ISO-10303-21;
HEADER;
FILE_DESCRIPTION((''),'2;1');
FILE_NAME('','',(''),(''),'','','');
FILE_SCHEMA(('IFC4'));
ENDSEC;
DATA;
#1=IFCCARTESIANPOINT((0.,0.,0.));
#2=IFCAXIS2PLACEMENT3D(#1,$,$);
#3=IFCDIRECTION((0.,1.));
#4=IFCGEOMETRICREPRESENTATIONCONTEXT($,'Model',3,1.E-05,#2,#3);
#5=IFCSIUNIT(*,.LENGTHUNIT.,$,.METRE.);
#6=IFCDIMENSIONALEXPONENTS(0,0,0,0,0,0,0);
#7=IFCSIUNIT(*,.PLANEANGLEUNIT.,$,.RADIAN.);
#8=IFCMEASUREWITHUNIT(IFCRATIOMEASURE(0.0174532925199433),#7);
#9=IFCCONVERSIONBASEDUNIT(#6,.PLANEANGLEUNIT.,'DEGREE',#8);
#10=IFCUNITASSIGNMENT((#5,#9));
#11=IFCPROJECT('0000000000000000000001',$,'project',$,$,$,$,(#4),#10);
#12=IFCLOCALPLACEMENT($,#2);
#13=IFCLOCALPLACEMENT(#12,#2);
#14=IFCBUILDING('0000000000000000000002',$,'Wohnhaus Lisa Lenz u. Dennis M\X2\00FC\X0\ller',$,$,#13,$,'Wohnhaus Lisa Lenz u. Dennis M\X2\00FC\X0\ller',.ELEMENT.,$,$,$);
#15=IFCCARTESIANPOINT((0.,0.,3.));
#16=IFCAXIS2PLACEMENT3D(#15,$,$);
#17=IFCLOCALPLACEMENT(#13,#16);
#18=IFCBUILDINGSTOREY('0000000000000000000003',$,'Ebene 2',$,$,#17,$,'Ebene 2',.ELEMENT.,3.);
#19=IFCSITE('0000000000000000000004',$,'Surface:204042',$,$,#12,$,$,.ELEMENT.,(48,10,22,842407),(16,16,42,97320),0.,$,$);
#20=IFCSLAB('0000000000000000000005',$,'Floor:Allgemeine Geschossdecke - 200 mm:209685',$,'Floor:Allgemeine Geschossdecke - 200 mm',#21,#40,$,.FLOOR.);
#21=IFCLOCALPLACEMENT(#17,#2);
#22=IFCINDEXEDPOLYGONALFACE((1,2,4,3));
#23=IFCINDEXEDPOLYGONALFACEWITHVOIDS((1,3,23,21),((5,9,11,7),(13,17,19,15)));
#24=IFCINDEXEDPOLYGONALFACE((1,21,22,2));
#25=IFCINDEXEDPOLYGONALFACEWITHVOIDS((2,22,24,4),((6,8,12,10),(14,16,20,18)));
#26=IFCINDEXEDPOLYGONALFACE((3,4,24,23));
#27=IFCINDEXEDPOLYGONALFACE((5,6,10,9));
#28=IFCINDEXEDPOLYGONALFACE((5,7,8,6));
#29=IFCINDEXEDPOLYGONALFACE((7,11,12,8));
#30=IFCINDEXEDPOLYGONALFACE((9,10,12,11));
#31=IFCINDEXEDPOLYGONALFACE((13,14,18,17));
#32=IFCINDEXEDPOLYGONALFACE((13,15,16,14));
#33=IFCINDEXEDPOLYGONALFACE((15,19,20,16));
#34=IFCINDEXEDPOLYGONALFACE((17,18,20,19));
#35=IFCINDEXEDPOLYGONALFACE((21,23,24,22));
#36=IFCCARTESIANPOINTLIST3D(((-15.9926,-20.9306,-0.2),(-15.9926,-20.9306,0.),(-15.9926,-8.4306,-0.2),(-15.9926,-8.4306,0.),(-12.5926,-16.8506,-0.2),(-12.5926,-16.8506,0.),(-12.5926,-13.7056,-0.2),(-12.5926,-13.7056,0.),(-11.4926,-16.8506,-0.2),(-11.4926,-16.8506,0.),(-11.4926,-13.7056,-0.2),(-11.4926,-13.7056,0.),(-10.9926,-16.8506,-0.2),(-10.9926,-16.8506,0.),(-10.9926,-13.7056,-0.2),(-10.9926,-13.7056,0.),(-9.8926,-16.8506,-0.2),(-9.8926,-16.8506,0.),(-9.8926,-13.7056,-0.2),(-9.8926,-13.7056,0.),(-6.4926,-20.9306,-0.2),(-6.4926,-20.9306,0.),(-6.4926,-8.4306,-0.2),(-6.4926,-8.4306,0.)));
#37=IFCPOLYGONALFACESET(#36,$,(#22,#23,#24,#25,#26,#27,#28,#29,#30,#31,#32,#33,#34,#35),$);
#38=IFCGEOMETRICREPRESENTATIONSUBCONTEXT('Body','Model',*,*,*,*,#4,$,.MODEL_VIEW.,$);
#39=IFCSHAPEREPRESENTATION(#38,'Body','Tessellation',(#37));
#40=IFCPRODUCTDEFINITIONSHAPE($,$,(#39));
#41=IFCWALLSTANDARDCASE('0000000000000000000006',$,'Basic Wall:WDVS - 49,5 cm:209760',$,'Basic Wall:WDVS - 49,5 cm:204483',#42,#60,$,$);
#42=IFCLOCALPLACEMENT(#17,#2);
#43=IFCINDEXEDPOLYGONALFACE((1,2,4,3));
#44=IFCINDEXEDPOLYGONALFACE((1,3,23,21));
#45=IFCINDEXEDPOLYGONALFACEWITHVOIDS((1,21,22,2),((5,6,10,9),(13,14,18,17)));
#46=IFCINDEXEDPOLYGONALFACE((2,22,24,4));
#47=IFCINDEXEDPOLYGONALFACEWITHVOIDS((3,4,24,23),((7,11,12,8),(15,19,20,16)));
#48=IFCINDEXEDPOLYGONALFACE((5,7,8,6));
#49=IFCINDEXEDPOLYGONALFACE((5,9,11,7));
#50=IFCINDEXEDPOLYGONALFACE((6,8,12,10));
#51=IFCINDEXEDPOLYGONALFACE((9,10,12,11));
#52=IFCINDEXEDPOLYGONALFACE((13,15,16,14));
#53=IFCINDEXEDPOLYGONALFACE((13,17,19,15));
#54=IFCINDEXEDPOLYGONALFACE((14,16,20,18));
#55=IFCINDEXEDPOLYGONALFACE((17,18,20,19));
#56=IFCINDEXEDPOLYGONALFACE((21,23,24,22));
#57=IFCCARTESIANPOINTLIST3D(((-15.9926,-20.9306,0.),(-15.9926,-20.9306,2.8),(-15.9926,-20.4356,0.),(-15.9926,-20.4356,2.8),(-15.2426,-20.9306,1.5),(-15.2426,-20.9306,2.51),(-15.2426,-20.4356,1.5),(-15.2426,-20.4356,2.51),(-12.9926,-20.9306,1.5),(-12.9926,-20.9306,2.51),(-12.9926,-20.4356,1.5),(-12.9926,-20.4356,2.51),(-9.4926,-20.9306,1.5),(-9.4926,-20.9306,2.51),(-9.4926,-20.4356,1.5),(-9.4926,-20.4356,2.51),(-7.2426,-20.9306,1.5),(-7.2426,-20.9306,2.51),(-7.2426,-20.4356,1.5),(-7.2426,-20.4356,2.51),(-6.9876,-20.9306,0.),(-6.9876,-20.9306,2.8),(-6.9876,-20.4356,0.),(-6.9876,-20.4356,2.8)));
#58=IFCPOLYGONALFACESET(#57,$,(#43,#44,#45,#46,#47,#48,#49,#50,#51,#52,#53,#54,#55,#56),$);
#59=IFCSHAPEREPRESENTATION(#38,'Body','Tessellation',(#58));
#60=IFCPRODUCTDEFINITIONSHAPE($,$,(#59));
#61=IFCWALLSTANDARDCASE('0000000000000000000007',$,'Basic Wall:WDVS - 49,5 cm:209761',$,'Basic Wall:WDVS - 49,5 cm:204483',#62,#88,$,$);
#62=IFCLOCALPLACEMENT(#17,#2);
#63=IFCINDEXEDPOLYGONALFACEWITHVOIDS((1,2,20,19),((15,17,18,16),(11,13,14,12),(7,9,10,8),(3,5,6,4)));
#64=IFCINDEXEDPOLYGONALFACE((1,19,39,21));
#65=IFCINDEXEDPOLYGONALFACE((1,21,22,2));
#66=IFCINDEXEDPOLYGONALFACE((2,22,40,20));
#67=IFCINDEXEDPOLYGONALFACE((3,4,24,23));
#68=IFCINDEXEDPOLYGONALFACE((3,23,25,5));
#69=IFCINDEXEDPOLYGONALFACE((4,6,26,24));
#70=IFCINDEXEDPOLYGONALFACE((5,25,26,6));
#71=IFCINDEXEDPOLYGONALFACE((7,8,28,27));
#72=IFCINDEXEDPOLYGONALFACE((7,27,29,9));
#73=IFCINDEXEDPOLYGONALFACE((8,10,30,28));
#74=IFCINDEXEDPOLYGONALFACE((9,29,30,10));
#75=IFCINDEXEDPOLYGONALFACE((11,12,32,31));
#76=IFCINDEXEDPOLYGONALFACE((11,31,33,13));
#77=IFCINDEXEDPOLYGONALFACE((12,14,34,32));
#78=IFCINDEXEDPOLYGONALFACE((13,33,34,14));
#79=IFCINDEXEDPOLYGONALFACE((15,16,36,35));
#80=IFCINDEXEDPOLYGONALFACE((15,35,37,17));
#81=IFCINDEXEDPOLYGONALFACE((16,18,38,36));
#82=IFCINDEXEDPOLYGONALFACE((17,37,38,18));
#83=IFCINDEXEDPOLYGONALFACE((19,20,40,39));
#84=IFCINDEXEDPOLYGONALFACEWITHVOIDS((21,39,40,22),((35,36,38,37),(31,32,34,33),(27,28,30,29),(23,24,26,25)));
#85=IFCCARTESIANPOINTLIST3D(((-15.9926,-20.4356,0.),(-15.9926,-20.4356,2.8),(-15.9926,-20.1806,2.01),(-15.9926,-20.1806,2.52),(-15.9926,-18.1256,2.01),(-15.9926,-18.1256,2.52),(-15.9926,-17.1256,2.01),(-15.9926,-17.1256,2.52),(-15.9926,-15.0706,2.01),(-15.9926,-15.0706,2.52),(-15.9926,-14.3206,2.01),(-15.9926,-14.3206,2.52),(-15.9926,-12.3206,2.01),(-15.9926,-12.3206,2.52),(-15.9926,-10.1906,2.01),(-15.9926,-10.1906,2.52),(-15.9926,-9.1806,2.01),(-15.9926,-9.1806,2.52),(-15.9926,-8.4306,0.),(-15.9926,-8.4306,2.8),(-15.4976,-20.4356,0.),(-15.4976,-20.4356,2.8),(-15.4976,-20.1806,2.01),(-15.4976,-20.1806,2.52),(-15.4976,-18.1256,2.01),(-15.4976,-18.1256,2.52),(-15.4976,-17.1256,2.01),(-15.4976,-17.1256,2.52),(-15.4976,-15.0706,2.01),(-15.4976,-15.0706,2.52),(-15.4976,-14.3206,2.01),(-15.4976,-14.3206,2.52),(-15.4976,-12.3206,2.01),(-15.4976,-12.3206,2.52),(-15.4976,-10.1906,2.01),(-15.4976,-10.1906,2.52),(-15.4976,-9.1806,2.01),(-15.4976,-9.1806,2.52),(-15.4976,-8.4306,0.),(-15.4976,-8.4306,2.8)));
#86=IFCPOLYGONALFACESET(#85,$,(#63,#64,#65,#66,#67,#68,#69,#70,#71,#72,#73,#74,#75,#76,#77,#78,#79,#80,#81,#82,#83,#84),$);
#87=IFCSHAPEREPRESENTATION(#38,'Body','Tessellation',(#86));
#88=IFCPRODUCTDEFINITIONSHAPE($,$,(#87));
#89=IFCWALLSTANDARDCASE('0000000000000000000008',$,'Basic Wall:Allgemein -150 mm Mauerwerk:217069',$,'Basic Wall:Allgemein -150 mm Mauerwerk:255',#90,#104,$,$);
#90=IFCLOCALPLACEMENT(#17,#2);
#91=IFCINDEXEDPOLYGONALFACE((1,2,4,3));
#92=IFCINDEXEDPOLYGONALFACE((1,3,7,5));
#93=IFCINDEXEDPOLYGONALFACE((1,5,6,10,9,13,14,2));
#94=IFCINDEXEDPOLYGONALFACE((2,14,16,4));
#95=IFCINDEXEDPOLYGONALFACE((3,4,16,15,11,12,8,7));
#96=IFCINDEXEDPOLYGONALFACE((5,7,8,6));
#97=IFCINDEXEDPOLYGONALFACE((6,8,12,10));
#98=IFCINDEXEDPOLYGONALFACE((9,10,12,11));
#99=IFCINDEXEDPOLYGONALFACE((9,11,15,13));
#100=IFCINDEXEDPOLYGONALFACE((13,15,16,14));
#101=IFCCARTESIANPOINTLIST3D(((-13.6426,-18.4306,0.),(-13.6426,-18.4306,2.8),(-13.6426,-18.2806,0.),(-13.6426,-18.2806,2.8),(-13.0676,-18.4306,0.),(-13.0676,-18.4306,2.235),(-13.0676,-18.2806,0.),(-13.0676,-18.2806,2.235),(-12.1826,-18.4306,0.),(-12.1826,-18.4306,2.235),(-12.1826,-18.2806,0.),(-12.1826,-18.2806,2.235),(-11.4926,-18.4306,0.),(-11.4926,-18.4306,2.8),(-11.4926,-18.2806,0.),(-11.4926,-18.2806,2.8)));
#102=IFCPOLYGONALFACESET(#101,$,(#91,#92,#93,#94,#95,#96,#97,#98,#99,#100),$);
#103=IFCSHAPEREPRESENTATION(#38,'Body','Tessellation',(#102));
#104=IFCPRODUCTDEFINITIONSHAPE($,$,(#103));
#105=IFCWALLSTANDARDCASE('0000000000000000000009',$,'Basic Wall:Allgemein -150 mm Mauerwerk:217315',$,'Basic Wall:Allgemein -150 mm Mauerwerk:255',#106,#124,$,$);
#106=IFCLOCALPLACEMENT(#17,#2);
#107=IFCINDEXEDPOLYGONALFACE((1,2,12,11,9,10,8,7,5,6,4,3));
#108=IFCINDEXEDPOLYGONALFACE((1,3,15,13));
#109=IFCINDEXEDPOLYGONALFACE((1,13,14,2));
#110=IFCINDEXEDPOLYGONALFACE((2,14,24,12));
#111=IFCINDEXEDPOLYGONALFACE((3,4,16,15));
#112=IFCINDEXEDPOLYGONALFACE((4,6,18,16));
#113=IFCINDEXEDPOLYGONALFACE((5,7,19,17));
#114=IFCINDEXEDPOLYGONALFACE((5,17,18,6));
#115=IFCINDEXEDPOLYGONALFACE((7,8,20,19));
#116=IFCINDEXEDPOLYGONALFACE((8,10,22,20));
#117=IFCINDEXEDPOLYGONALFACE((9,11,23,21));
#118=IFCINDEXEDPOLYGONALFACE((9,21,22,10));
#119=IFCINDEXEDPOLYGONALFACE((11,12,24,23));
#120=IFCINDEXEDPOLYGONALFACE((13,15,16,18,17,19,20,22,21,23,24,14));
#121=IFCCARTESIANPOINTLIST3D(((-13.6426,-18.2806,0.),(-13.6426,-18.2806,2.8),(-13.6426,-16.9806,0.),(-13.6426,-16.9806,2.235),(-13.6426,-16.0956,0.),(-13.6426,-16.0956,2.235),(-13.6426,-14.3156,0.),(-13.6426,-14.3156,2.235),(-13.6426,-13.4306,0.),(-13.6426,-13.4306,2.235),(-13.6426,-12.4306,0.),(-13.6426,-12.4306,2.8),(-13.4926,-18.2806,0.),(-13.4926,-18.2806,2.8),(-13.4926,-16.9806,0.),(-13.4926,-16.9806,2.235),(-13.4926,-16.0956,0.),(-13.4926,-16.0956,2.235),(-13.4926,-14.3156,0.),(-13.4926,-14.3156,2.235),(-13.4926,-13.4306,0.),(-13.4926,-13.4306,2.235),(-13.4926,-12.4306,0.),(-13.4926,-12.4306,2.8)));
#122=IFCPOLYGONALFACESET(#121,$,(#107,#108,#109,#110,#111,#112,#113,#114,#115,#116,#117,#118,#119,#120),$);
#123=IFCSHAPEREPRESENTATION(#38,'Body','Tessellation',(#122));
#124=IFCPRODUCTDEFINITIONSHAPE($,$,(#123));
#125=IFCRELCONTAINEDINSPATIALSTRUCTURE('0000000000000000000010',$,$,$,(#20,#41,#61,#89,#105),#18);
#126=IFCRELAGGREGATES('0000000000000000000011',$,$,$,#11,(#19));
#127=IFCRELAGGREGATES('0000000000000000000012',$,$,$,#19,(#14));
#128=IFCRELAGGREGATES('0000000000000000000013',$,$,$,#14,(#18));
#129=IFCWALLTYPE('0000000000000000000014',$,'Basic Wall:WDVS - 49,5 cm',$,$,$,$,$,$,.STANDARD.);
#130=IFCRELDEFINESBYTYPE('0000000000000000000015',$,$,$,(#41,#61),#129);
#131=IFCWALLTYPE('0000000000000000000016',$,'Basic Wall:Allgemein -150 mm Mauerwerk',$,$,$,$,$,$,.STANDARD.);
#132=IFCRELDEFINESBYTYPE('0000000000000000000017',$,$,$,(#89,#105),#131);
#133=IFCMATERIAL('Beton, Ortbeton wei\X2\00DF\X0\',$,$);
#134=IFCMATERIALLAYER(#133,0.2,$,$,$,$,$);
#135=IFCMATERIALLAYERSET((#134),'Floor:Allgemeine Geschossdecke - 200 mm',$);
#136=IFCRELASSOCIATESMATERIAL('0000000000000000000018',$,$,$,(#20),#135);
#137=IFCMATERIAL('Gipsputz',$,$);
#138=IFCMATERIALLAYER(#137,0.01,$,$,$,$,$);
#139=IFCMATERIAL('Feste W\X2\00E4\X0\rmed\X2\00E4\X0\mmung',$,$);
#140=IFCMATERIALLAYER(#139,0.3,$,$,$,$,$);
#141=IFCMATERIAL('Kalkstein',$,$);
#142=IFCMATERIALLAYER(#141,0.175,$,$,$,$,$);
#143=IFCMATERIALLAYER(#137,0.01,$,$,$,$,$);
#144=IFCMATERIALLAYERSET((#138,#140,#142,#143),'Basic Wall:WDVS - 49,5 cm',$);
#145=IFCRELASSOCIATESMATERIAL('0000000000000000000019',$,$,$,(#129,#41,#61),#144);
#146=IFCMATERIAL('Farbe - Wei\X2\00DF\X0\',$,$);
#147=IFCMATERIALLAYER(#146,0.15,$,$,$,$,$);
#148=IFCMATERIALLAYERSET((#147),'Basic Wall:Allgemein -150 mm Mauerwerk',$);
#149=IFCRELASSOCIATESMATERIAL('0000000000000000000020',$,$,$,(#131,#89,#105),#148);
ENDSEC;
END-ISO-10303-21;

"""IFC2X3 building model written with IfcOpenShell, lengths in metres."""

from ifc_helpers import new_model, entity, si_unit, converted_unit, direction, frame, frame_2d, origin, origin_2d_with_axis, place, context, subcontext, project, spatial, polyline, rectangle, extrude, clip, bounded_halfspace, material, layer, layer_set, layer_usage, type_object, element, save


model = new_model("IFC2X3")

# Units and contexts
model_context = context("Model", 3, precision=1e-05, world=origin(), true_north=direction((0.0, 1.0)))
body_context = subcontext(model_context, "Body", "Model", "MODEL_VIEW")
ifc_project = project(units=[si_unit("LENGTHUNIT", "METRE"), converted_unit("PLANEANGLEUNIT", "DEGREE", entity("IfcRatioMeasure", 0.0174532925199433), si_unit("PLANEANGLEUNIT", "RADIAN"), dimensions=[0, 0, 0, 0, 0, 0, 0])], contexts=[model_context])

# Site, building, storey
site_placement = place(None, origin())
site = spatial("IfcSite", under=ifc_project, at=site_placement, Name="Surface:204042", CompositionType="ELEMENT", RefLatitude=(48, 10, 22, 842407), RefLongitude=(16, 16, 42, 97320), RefElevation=0.0)
building_placement = place(site_placement, origin())
building = spatial("IfcBuilding", under=site, at=building_placement, Name="Wohnhaus Lisa Lenz u. Dennis Müller", LongName="Wohnhaus Lisa Lenz u. Dennis Müller", CompositionType="ELEMENT")
storey_placement = place(building_placement, frame((0.0, 0.0, 3.0)))
storey = spatial("IfcBuildingStorey", under=building, at=storey_placement, Name="Ebene 2", LongName="Ebene 2", CompositionType="ELEMENT", Elevation=3.0)

# Slab, openings
ifc_material_1 = material(Name="Beton, Ortbeton weiß")
ifc_layer_1 = layer(ifc_material_1, 0.2)
ifc_layer_set_1 = layer_set([ifc_layer_1], Name="Floor:Allgemeine Geschossdecke - 200 mm")
ifc_layer_usage_1 = layer_usage(ifc_layer_set_1, "AXIS3", "POSITIVE", 0.0)
slab_placement = place(storey_placement, frame((-15.9926, -20.9306, -0.2)))
slab = element("IfcSlab", 1, at=slab_placement, inside=storey, material=ifc_layer_usage_1, Name="Floor:Allgemeine Geschossdecke - 200 mm:209685", ObjectType="Floor:Allgemeine Geschossdecke - 200 mm", PredefinedType="FLOOR", context=body_context, shape_type="SweptSolid", body=[
    extrude(rectangle(XDim=9.5, YDim=12.5, at=origin_2d_with_axis()), frame((4.75, 6.25, 0.2), z_axis=(0.0, 0.0, -1.0), x_axis=(-1.0, 0.0, 0.0)), (0.0, 0.0, 1.0), 0.2),
])
opening_1_placement = place(slab_placement, frame((5.55, 5.6525, 0.2)))
element("IfcOpeningElement", 2, at=opening_1_placement, cuts=slab, ObjectType="Opening", context=body_context, shape_type="SweptSolid", body=[
    extrude(rectangle(XDim=3.145, YDim=1.1, at=origin_2d_with_axis()), frame((0.0, 0.0, 0.0), z_axis=(0.0, 0.0, -1.0), x_axis=(0.0, -1.0, 0.0)), (0.0, 0.0, 1.0), 0.2),
])
opening_2_placement = place(slab_placement, frame((3.95, 5.6525, 0.2)))
element("IfcOpeningElement", 3, at=opening_2_placement, cuts=slab, ObjectType="Opening", context=body_context, shape_type="SweptSolid", body=[
    extrude(rectangle(XDim=3.145, YDim=1.1, at=origin_2d_with_axis()), frame((0.0, 0.0, 0.0), z_axis=(0.0, 0.0, -1.0), x_axis=(0.0, -1.0, 0.0)), (0.0, 0.0, 1.0), 0.2),
])

# Walls, openings
ifc_material_2 = material(Name="Gipsputz")
ifc_layer_2 = layer(ifc_material_2, 0.01)
ifc_material_3 = material(Name="Feste Wärmedämmung")
ifc_layer_3 = layer(ifc_material_3, 0.3)
ifc_material_4 = material(Name="Kalkstein")
ifc_layer_4 = layer(ifc_material_4, 0.175)
ifc_layer_5 = layer(ifc_material_2, 0.01)
ifc_layer_set_2 = layer_set([ifc_layer_2, ifc_layer_3, ifc_layer_4, ifc_layer_5], Name="Basic Wall:WDVS - 49,5 cm")
ifc_layer_usage_2 = layer_usage(ifc_layer_set_2, "AXIS2", "NEGATIVE", 0.2475)
wall_type_1 = type_object("IfcWallType", Name="Basic Wall:WDVS - 49,5 cm", PredefinedType="STANDARD", material=ifc_layer_set_2)
wall_1_placement = place(storey_placement, frame((-6.9876, -20.6831, 0.0), z_axis=(0.0, 0.0, 1.0), x_axis=(-1.0, 0.0, 0.0)))
wall_1 = element("IfcWallStandardCase", 4, at=wall_1_placement, inside=storey, type_object=wall_type_1, material=ifc_layer_usage_2, Name="Basic Wall:WDVS - 49,5 cm:209760", ObjectType="Basic Wall:WDVS - 49,5 cm:204483", context=body_context, shape_type="Clipping", body=[
    clip(extrude(rectangle(XDim=9.005, YDim=0.495, at=frame_2d((4.5025, 0.0), x_axis=(-1.0, 0.0))), origin(), (0.0, 0.0, 1.0), 2.8), bounded_halfspace(frame((0.0, -0.2475, 2.8), z_axis=(0.0, 0.0, -1.0), x_axis=(0.0, 1.0, 0.0)), True, frame((0.0, -0.2475, 2.8)), polyline([(0.0, 0.0), (4.005, 0.0), (4.505, 0.0), (8.51, 0.0), (9.005, 0.0), (9.005, 0.495), (0.0, 0.495), (0.0, 0.0)]))),
])
opening_3_placement = place(wall_1_placement, frame((8.255, 0.2475, 1.5)))
element("IfcOpeningElement", 5, at=opening_3_placement, cuts=wall_1, ObjectType="Opening", context=body_context, shape_type="SweptSolid", body=[
    extrude(rectangle(XDim=1.01, YDim=2.25, at=frame_2d((0.505, 1.125), x_axis=(1.0, 0.0))), frame((0.0, 0.0, 0.0), z_axis=(0.0, -1.0, 0.0), x_axis=(0.0, 0.0, 1.0)), (0.0, 0.0, 1.0), 0.495),
])
opening_4_placement = place(wall_1_placement, frame((2.505, 0.2475, 1.5)))
element("IfcOpeningElement", 6, at=opening_4_placement, cuts=wall_1, ObjectType="Opening", context=body_context, shape_type="SweptSolid", body=[
    extrude(rectangle(XDim=1.01, YDim=2.25, at=frame_2d((0.505, 1.125), x_axis=(1.0, 0.0))), frame((0.0, 0.0, 0.0), z_axis=(0.0, -1.0, 0.0), x_axis=(0.0, 0.0, 1.0)), (0.0, 0.0, 1.0), 0.495),
])
ifc_layer_usage_3 = layer_usage(ifc_layer_set_2, "AXIS2", "NEGATIVE", 0.2475)
wall_2_placement = place(storey_placement, frame((-15.7451, -20.4356, 0.0), z_axis=(0.0, 0.0, 1.0), x_axis=(0.0, 1.0, 0.0)))
wall_2 = element("IfcWallStandardCase", 7, at=wall_2_placement, inside=storey, type_object=wall_type_1, material=ifc_layer_usage_3, Name="Basic Wall:WDVS - 49,5 cm:209761", ObjectType="Basic Wall:WDVS - 49,5 cm:204483", context=body_context, shape_type="Clipping", body=[
    clip(extrude(rectangle(XDim=12.005, YDim=0.495, at=frame_2d((6.0025, 0.0), x_axis=(-1.0, 0.0))), origin(), (0.0, 0.0, 1.0), 2.8), bounded_halfspace(frame((0.0, -0.2475, 2.8), z_axis=(0.0, 0.0, -1.0), x_axis=(-1.0, 0.0, 0.0)), True, frame((0.0, -0.2475, 2.8)), polyline([(0.0, 0.0), (2.555, 0.0), (2.705, 0.0), (4.855, 0.0), (5.005, 0.0), (9.205, 0.0), (9.355, 0.0), (11.51, 0.0), (12.005, 0.0), (12.005, 0.495), (0.0, 0.495), (0.0, 0.0)]))),
])
opening_5_placement = place(wall_2_placement, frame((2.31, 0.2475, 2.01)))
element("IfcOpeningElement", 8, at=opening_5_placement, cuts=wall_2, ObjectType="Opening", context=body_context, shape_type="SweptSolid", body=[
    extrude(rectangle(XDim=0.51, YDim=2.055, at=frame_2d((0.255, 1.0275), x_axis=(1.0, 0.0))), frame((0.0, 0.0, 0.0), z_axis=(0.0, -1.0, 0.0), x_axis=(0.0, 0.0, 1.0)), (0.0, 0.0, 1.0), 0.495),
])
opening_6_placement = place(wall_2_placement, frame((10.245, -0.2475, 2.01)))
element("IfcOpeningElement", 9, at=opening_6_placement, cuts=wall_2, ObjectType="Opening", context=body_context, shape_type="SweptSolid", body=[
    extrude(rectangle(XDim=0.51, YDim=1.01, at=frame_2d((0.255, 0.505), x_axis=(1.0, 0.0))), frame((0.0, 0.0, 0.0), z_axis=(0.0, 1.0, 0.0), x_axis=(0.0, 0.0, 1.0)), (0.0, 0.0, 1.0), 0.495),
])
opening_7_placement = place(wall_2_placement, frame((8.115, 0.2475, 2.01)))
element("IfcOpeningElement", 10, at=opening_7_placement, cuts=wall_2, ObjectType="Opening", context=body_context, shape_type="SweptSolid", body=[
    extrude(rectangle(XDim=0.51, YDim=2.0, at=frame_2d((0.255, 1.0), x_axis=(1.0, 0.0))), frame((0.0, 0.0, 0.0), z_axis=(0.0, -1.0, 0.0), x_axis=(0.0, 0.0, 1.0)), (0.0, 0.0, 1.0), 0.495),
])
opening_8_placement = place(wall_2_placement, frame((5.365, 0.2475, 2.01)))
element("IfcOpeningElement", 11, at=opening_8_placement, cuts=wall_2, ObjectType="Opening", context=body_context, shape_type="SweptSolid", body=[
    extrude(rectangle(XDim=0.51, YDim=2.055, at=frame_2d((0.255, 1.0275), x_axis=(1.0, 0.0))), frame((0.0, 0.0, 0.0), z_axis=(0.0, -1.0, 0.0), x_axis=(0.0, 0.0, 1.0)), (0.0, 0.0, 1.0), 0.495),
])

# Wall, opening
ifc_material_5 = material(Name="Farbe - Weiß")
ifc_layer_6 = layer(ifc_material_5, 0.15)
ifc_layer_set_3 = layer_set([ifc_layer_6], Name="Basic Wall:Allgemein -150 mm Mauerwerk")
ifc_layer_usage_4 = layer_usage(ifc_layer_set_3, "AXIS2", "NEGATIVE", 0.075)
wall_type_2 = type_object("IfcWallType", Name="Basic Wall:Allgemein -150 mm Mauerwerk", PredefinedType="STANDARD", material=ifc_layer_set_3)
wall_3_placement = place(storey_placement, frame((-11.4926, -18.3556, 0.0), z_axis=(0.0, 0.0, 1.0), x_axis=(-1.0, 0.0, 0.0)))
wall_3 = element("IfcWallStandardCase", 12, at=wall_3_placement, inside=storey, type_object=wall_type_2, material=ifc_layer_usage_4, Name="Basic Wall:Allgemein -150 mm Mauerwerk:217069", ObjectType="Basic Wall:Allgemein -150 mm Mauerwerk:255", context=body_context, shape_type="Clipping", body=[
    clip(extrude(rectangle(XDim=2.15, YDim=0.15, at=frame_2d((1.075, 0.0), x_axis=(-1.0, 0.0))), origin(), (0.0, 0.0, 1.0), 2.8), bounded_halfspace(frame((0.0, -0.075, 2.8), z_axis=(0.0, 0.0, -1.0), x_axis=(0.0, 1.0, 0.0)), True, frame((0.0, -0.075, 2.8)), polyline([(0.0, 0.0), (2.0, 0.0), (2.15, 0.0), (2.15, 0.15), (0.0, 0.15), (0.0, 0.0)]))),
])
opening_9_placement = place(wall_3_placement, frame((0.69, -0.075, 0.0)))
element("IfcOpeningElement", 13, at=opening_9_placement, cuts=wall_3, ObjectType="Opening", context=body_context, shape_type="SweptSolid", body=[
    extrude(rectangle(XDim=2.235, YDim=0.885, at=frame_2d((1.1175, 0.4425), x_axis=(1.0, 0.0))), frame((0.0, 0.0, 0.0), z_axis=(0.0, 1.0, 0.0), x_axis=(0.0, 0.0, 1.0)), (0.0, 0.0, 1.0), 0.15),
])

# Wall, openings
ifc_layer_usage_5 = layer_usage(ifc_layer_set_3, "AXIS2", "NEGATIVE", 0.075)
wall_4_placement = place(storey_placement, frame((-13.5676, -18.2806, 0.0), z_axis=(0.0, 0.0, 1.0), x_axis=(0.0, 1.0, 0.0)))
wall_4 = element("IfcWallStandardCase", 14, at=wall_4_placement, inside=storey, type_object=wall_type_2, material=ifc_layer_usage_5, Name="Basic Wall:Allgemein -150 mm Mauerwerk:217315", ObjectType="Basic Wall:Allgemein -150 mm Mauerwerk:255", context=body_context, shape_type="Clipping", body=[
    clip(extrude(rectangle(XDim=5.85, YDim=0.15, at=frame_2d((2.925, 0.0), x_axis=(-1.0, 0.0))), origin(), (0.0, 0.0, 1.0), 2.8), bounded_halfspace(frame((0.0, -0.075, 2.8), z_axis=(0.0, 0.0, -1.0), x_axis=(-1.0, 0.0, 0.0)), True, frame((0.0, -0.075, 2.8)), polyline([(0.0, 0.0), (5.7, 0.0), (5.85, 0.0), (5.85, 0.15), (5.7, 0.15), (2.85, 0.15), (2.7, 0.15), (0.55, 0.15), (0.4, 0.15), (0.0, 0.15), (0.0, 0.0)]))),
])
opening_10_placement = place(wall_4_placement, frame((1.3, -0.075, 0.0)))
element("IfcOpeningElement", 15, at=opening_10_placement, cuts=wall_4, ObjectType="Opening", context=body_context, shape_type="SweptSolid", body=[
    extrude(rectangle(XDim=2.235, YDim=0.885, at=frame_2d((1.1175, 0.4425), x_axis=(1.0, 0.0))), frame((0.0, 0.0, 0.0), z_axis=(0.0, 1.0, 0.0), x_axis=(0.0, 0.0, 1.0)), (0.0, 0.0, 1.0), 0.15),
])
opening_11_placement = place(wall_4_placement, frame((3.965, -0.075, 0.0)))
element("IfcOpeningElement", 16, at=opening_11_placement, cuts=wall_4, ObjectType="Opening", context=body_context, shape_type="SweptSolid", body=[
    extrude(rectangle(XDim=2.235, YDim=0.885, at=frame_2d((1.1175, 0.4425), x_axis=(1.0, 0.0))), frame((0.0, 0.0, 0.0), z_axis=(0.0, 1.0, 0.0), x_axis=(0.0, 0.0, 1.0)), (0.0, 0.0, 1.0), 0.15),
])

save(model, "model.ifc")
